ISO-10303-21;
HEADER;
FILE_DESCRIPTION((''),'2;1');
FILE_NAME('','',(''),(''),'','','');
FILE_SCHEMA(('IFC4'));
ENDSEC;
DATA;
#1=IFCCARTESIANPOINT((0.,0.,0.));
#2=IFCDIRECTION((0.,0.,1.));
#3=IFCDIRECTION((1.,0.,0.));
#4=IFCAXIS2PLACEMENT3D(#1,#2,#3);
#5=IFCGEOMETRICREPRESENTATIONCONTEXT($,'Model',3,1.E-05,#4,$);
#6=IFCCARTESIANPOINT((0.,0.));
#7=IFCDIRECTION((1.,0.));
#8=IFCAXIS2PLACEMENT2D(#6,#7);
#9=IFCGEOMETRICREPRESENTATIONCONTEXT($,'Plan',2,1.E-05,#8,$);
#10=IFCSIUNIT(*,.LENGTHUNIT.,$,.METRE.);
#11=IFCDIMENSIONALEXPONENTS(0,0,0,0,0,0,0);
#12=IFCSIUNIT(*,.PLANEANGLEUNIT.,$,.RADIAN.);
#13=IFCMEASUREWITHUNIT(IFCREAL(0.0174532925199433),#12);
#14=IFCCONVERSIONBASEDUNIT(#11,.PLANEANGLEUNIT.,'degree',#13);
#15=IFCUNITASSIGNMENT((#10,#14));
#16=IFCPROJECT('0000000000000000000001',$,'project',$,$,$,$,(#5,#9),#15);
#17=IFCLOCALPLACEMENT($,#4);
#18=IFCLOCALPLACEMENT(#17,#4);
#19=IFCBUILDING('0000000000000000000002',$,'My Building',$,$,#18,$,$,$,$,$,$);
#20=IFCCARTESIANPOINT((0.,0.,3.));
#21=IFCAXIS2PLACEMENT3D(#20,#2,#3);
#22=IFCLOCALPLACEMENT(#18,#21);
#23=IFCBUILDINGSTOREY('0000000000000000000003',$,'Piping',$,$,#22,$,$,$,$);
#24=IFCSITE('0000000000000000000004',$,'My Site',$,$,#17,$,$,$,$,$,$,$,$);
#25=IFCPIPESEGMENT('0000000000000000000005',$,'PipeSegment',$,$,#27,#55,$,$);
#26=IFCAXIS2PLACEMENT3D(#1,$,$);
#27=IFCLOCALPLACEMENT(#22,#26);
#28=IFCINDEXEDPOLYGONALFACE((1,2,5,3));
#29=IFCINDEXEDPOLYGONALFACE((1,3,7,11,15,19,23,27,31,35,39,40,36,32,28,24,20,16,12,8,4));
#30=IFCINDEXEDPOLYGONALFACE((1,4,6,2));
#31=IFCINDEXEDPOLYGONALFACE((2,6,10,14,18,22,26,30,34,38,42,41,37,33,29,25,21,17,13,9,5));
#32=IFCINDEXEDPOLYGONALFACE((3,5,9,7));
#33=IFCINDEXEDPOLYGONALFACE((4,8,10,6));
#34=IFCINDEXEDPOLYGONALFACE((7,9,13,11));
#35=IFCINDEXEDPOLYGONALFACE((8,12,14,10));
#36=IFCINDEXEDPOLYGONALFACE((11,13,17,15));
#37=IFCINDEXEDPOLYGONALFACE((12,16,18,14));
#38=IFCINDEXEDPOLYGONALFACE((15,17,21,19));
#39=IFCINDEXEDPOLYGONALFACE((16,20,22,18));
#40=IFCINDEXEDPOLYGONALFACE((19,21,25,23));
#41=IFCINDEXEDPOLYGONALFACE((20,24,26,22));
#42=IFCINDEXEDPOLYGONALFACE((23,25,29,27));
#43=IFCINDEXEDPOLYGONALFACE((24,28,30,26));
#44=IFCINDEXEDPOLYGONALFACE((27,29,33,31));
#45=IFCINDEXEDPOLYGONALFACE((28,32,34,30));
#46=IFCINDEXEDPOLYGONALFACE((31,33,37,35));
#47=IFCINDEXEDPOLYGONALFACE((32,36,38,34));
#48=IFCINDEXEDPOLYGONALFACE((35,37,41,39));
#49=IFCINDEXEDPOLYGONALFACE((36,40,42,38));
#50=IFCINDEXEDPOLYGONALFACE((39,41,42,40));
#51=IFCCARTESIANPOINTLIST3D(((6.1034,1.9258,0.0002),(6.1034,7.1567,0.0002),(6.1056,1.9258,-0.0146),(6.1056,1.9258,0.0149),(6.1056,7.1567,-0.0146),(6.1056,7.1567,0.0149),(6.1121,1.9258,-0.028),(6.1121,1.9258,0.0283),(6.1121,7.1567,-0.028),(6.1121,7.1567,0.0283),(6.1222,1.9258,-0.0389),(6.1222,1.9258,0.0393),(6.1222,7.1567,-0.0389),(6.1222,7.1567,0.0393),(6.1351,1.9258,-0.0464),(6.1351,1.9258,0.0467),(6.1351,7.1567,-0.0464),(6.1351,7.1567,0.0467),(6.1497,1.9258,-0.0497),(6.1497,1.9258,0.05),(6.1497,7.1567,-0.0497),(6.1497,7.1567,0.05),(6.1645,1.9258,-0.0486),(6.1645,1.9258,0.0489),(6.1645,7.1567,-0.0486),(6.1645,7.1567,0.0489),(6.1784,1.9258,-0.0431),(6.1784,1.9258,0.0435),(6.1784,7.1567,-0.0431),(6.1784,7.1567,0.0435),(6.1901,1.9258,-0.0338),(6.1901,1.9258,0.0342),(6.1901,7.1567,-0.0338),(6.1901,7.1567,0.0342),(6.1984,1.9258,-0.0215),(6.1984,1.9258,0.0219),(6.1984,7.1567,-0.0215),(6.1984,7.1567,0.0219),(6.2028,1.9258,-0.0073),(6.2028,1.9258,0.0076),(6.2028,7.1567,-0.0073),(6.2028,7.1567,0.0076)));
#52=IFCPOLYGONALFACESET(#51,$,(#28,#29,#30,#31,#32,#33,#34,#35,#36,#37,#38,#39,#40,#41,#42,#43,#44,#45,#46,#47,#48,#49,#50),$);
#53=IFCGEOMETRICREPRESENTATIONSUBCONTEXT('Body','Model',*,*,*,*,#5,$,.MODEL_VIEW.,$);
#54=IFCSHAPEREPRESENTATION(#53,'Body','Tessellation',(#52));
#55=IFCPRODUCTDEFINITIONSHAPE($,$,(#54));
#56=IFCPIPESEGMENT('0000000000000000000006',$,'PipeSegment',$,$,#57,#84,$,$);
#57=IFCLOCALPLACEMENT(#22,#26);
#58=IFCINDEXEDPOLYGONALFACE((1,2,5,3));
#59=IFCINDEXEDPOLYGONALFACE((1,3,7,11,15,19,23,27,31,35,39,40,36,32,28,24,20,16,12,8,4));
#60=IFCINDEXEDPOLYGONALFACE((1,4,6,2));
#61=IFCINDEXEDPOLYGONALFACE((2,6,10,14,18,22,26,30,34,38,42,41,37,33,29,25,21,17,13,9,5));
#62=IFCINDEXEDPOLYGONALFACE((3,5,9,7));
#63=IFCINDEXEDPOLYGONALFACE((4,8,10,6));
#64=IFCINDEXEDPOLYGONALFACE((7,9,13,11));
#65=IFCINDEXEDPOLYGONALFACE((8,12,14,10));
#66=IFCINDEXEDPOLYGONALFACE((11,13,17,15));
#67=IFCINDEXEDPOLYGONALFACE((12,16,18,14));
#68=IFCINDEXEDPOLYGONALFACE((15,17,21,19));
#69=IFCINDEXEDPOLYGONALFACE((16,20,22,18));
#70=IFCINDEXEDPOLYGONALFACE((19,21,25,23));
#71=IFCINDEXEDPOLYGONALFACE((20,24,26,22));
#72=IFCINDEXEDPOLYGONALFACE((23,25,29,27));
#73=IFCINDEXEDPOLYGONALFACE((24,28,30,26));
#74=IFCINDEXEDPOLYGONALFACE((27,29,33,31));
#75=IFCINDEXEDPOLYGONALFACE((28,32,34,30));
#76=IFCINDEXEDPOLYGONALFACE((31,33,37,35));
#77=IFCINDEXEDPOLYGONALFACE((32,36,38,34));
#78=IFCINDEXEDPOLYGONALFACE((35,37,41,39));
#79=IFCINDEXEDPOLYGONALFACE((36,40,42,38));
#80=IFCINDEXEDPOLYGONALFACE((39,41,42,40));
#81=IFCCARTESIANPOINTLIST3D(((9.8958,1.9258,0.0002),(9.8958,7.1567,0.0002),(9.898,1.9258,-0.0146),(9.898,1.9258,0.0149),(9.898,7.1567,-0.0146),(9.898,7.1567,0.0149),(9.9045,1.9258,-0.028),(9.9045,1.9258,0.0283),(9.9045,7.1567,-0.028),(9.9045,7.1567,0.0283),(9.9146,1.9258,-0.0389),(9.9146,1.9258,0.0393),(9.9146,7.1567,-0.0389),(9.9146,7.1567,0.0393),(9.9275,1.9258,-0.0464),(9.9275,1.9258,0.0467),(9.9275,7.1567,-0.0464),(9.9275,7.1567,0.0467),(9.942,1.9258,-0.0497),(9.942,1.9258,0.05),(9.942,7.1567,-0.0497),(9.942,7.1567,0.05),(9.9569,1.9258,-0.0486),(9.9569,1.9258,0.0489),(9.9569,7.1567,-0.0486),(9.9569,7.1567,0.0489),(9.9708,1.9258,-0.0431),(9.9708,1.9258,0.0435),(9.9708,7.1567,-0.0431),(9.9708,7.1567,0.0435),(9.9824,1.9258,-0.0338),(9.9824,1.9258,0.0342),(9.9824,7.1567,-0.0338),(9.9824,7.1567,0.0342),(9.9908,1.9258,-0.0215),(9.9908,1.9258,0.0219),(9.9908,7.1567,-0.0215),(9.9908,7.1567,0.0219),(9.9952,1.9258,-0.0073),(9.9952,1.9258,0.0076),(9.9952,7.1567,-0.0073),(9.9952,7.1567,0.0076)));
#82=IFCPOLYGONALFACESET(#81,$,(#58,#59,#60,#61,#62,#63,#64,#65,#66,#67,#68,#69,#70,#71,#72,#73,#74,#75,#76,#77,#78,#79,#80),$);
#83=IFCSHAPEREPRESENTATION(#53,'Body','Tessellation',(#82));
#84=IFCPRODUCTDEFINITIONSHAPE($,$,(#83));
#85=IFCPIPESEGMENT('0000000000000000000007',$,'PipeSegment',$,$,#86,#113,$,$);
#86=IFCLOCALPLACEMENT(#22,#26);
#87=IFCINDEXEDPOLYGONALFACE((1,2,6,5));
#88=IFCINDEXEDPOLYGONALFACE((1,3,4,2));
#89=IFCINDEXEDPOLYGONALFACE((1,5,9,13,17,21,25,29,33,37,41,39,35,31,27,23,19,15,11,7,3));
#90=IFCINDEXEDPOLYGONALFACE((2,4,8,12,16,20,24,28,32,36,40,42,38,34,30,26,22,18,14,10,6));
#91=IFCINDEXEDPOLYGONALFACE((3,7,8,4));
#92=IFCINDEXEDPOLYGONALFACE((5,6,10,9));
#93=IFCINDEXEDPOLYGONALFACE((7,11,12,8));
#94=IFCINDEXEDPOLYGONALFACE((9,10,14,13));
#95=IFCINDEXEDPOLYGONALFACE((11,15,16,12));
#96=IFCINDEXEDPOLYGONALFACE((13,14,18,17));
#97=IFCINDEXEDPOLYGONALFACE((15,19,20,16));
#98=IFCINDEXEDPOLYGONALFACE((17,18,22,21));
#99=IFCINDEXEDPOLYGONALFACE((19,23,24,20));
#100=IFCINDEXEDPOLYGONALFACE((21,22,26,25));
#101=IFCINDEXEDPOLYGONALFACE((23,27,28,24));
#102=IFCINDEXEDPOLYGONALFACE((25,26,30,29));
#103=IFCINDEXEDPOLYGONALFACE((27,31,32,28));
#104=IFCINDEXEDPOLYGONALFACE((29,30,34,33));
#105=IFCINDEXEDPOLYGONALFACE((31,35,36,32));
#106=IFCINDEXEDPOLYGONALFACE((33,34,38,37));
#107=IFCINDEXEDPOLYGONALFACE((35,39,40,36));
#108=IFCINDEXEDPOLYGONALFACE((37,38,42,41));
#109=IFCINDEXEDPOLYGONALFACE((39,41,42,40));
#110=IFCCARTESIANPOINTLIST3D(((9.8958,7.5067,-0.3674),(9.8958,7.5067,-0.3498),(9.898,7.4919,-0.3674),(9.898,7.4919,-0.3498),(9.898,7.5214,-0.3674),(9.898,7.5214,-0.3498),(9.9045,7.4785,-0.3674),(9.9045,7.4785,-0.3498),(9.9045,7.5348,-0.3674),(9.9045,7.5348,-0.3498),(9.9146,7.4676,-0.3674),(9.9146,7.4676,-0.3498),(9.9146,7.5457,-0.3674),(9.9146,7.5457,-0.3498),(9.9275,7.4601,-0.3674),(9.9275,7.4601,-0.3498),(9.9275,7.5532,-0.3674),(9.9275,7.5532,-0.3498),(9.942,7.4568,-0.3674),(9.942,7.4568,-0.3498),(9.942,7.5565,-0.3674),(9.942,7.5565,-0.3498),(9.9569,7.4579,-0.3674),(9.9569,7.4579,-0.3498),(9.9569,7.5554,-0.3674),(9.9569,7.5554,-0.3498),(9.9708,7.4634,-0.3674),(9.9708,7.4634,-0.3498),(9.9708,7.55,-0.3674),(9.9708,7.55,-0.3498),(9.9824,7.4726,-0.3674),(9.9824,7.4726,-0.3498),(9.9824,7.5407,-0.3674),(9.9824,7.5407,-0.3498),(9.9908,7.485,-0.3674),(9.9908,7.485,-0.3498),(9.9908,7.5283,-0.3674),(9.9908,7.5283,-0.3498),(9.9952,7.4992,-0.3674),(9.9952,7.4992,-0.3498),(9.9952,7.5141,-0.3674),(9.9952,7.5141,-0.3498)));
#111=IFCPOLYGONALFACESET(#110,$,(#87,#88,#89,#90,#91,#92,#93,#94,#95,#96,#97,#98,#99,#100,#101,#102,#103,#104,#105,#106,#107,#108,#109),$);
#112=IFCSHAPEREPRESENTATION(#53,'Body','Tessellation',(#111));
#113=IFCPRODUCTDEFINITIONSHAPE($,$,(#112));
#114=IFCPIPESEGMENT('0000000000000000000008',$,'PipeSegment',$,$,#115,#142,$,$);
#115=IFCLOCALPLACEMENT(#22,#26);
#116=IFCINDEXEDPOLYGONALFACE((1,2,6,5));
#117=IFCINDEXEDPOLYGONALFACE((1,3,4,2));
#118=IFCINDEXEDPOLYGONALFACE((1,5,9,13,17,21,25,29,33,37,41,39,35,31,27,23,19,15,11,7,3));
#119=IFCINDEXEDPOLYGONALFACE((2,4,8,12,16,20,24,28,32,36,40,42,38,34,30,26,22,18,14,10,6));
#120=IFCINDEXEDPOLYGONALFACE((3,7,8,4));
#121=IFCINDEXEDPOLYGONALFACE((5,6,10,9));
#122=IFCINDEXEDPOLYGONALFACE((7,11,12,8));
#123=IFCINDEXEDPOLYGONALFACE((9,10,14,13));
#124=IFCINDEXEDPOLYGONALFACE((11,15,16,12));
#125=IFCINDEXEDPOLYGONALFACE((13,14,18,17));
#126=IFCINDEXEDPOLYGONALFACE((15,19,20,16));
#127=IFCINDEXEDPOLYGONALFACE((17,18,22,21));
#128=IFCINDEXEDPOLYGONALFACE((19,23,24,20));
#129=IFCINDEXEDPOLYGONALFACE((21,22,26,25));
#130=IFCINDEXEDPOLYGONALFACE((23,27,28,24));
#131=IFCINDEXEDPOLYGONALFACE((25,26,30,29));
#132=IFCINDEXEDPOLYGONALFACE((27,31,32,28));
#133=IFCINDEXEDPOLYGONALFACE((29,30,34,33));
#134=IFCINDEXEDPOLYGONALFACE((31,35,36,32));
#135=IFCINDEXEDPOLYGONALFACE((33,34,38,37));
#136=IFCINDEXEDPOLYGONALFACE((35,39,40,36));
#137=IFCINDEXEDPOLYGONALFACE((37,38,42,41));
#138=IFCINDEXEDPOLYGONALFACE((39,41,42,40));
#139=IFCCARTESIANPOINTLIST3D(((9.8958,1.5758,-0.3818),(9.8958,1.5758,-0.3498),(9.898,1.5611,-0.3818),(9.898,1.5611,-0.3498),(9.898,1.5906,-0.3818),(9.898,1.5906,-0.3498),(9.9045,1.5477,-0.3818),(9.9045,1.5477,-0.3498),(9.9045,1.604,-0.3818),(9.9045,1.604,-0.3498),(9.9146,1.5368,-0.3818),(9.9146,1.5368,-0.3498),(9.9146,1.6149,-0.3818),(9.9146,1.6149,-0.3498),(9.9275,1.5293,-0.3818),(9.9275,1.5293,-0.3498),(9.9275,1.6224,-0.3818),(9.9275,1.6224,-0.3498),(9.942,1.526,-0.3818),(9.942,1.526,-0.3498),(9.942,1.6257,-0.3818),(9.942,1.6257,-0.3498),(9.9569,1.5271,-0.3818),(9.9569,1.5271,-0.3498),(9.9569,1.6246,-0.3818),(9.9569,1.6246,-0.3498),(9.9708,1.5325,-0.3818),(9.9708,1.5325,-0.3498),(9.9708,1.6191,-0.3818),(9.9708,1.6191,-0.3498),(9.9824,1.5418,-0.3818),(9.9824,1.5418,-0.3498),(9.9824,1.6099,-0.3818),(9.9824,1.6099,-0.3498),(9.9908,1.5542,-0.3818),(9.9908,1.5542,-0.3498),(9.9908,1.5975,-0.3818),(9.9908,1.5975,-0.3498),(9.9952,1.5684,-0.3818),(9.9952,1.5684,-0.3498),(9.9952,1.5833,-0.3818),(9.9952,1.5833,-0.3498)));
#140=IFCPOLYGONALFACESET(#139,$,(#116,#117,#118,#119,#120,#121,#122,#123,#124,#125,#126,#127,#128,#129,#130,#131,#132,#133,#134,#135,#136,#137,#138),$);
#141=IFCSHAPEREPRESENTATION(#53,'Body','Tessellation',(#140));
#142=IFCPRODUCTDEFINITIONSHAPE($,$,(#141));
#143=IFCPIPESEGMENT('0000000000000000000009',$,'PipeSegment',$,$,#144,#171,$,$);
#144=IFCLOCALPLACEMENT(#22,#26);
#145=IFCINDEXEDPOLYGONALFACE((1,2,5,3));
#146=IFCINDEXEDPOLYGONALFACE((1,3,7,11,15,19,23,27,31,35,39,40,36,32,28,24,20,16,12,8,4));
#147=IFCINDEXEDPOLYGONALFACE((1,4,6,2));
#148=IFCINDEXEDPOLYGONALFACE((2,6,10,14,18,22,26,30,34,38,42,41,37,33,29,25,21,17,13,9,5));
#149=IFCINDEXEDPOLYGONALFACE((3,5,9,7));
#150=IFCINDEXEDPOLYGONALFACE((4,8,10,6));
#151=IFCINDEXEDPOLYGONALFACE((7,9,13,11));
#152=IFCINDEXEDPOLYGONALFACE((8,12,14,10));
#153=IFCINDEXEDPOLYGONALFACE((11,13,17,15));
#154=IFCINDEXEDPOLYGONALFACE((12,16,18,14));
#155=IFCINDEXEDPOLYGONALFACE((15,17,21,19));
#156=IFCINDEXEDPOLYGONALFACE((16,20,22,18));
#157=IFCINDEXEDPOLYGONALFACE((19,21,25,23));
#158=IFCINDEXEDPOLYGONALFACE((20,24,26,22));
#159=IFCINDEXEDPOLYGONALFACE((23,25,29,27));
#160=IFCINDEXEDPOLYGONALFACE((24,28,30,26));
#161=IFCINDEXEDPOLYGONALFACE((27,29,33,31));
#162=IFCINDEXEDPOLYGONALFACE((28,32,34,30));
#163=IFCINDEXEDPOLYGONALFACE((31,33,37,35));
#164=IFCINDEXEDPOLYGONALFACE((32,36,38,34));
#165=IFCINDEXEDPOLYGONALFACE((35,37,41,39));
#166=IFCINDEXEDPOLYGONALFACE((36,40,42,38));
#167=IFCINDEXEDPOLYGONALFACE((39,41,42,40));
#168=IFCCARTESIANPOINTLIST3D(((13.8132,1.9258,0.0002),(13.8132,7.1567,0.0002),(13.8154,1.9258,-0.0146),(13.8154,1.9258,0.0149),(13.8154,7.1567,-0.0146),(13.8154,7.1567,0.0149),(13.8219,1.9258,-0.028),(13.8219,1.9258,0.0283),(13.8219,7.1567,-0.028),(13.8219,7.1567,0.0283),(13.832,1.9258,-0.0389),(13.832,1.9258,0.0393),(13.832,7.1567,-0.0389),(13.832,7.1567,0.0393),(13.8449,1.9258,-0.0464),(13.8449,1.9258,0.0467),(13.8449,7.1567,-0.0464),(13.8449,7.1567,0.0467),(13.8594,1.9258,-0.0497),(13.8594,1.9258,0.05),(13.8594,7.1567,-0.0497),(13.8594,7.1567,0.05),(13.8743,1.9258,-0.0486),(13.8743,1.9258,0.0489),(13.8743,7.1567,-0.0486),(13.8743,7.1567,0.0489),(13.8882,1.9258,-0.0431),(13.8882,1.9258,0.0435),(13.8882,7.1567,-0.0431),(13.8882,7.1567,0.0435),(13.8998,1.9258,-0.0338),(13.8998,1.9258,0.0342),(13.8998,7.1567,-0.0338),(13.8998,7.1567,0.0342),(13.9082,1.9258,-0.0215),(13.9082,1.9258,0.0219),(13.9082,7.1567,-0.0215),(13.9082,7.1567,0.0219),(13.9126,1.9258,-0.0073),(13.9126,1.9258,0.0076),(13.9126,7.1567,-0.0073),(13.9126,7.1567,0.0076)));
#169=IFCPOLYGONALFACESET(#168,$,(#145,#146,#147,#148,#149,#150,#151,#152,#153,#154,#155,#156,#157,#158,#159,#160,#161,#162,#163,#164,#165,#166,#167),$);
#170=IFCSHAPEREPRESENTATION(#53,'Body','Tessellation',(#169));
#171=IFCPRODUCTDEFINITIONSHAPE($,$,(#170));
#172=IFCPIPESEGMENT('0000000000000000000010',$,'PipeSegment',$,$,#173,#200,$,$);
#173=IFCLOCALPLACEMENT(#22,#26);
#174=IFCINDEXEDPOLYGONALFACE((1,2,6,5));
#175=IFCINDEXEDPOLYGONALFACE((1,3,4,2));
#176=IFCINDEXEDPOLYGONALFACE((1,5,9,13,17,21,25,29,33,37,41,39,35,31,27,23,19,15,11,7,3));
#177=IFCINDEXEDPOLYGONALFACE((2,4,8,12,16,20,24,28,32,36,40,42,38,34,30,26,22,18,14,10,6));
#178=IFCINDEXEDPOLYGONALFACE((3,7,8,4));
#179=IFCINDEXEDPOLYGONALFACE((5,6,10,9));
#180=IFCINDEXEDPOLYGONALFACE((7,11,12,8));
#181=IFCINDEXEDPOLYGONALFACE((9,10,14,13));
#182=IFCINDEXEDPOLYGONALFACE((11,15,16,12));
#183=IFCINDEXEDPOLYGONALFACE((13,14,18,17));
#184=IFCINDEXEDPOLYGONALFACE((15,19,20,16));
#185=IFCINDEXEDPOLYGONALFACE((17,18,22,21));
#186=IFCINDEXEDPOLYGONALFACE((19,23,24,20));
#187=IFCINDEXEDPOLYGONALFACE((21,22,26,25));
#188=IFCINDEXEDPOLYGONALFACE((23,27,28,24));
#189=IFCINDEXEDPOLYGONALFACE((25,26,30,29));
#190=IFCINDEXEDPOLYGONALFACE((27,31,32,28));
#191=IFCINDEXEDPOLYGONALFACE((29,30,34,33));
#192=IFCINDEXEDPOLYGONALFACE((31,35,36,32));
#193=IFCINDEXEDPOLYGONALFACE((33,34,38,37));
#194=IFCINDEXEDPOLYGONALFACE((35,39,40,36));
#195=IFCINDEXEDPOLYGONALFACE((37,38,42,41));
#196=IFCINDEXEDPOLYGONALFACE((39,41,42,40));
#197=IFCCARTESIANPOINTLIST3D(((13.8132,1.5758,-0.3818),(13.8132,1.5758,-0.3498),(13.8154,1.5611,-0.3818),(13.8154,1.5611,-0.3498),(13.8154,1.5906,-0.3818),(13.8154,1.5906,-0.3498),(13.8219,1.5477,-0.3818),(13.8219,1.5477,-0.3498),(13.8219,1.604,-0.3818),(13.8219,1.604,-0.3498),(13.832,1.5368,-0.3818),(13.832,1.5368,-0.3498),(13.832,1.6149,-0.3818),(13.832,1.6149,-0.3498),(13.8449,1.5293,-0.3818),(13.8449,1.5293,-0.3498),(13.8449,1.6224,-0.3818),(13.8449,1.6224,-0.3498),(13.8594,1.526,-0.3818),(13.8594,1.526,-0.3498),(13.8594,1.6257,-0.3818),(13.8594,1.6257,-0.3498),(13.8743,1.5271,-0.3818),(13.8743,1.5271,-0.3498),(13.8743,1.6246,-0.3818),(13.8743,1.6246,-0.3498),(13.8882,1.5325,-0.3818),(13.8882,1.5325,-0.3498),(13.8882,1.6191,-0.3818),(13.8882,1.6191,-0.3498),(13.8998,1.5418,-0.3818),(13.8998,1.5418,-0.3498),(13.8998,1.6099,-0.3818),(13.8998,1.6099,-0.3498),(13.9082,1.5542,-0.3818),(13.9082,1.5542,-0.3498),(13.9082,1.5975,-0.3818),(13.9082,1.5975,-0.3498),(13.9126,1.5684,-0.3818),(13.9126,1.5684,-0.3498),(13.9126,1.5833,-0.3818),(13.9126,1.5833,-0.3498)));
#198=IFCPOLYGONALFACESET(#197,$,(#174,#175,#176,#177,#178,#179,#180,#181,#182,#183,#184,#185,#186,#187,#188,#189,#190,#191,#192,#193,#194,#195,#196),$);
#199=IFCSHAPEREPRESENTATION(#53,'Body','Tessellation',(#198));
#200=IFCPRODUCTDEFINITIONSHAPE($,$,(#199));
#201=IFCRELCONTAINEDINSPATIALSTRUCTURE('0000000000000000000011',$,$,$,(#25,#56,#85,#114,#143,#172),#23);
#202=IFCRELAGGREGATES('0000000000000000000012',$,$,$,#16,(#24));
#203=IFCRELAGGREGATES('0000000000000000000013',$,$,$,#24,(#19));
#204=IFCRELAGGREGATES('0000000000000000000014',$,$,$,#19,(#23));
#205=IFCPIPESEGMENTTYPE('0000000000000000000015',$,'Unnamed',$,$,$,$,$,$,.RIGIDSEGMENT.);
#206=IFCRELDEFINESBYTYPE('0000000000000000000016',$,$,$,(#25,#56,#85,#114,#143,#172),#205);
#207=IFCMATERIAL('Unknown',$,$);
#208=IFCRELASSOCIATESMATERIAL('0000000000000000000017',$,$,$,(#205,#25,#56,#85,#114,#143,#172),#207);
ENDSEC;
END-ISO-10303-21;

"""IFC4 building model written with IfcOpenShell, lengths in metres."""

from ifc_helpers import new_model, entity, si_unit, converted_unit, frame, origin_with_axes, origin_2d_with_axis, place, context, subcontext, project, spatial, circle, extrude, material, material_profile, profile_set, profile_usage, type_object, element, save


model = new_model("IFC4")

# Units and contexts
model_context = context("Model", 3, precision=1e-05, world=origin_with_axes())
plan_context = context("Plan", 2, precision=1e-05, world=origin_2d_with_axis())
body_context = subcontext(model_context, "Body", "Model", "MODEL_VIEW")
ifc_project = project(units=[si_unit("LENGTHUNIT", "METRE"), converted_unit("PLANEANGLEUNIT", "degree", entity("IfcReal", 0.0174532925199433), si_unit("PLANEANGLEUNIT", "RADIAN"), dimensions=[0, 0, 0, 0, 0, 0, 0])], contexts=[model_context, plan_context])

# Site, building, storey
site_placement = place(None, origin_with_axes())
site = spatial("IfcSite", under=ifc_project, at=site_placement, Name="My Site")
building_placement = place(site_placement, origin_with_axes())
building = spatial("IfcBuilding", under=site, at=building_placement, Name="My Building")
storey_placement = place(building_placement, frame((0.0, 0.0, 3.0), z_axis=(0.0, 0.0, 1.0), x_axis=(1.0, 0.0, 0.0)))
storey = spatial("IfcBuildingStorey", under=building, at=storey_placement, Name="Piping")

# Pipe segments
ifc_material = material(Name="Unknown")
ifc_material_profile = material_profile(ifc_material, circle(Radius=0.05))
ifc_profile_set = profile_set([ifc_material_profile])
pipe_segment_type = type_object("IfcPipeSegmentType", Name="Unnamed", PredefinedType="RIGIDSEGMENT", material=ifc_profile_set)
ifc_profile_usage_1 = profile_usage(ifc_profile_set, cardinal=5)
pipe_segment_1_placement = place(storey_placement, frame((6.1534, 1.9258, 0.0002), z_axis=(0.0, 1.0, 0.0), x_axis=(-1.0, 0.0, 0.0)))
element("IfcPipeSegment", 1, at=pipe_segment_1_placement, inside=storey, type_object=pipe_segment_type, material=ifc_profile_usage_1, Name="PipeSegment", context=body_context, shape_type="SweptSolid", body=[
    extrude(circle(Radius=0.05), origin_with_axes(), (0.0, 0.0, 1.0), 5.2308),
])
ifc_profile_usage_2 = profile_usage(ifc_profile_set, cardinal=5)
pipe_segment_2_placement = place(storey_placement, frame((9.9458, 1.9258, 0.0002), z_axis=(0.0, 1.0, 0.0), x_axis=(-1.0, 0.0, 0.0)))
element("IfcPipeSegment", 2, at=pipe_segment_2_placement, inside=storey, type_object=pipe_segment_type, material=ifc_profile_usage_2, Name="PipeSegment", context=body_context, shape_type="SweptSolid", body=[
    extrude(circle(Radius=0.05), origin_with_axes(), (0.0, 0.0, 1.0), 5.2308),
])
ifc_profile_usage_3 = profile_usage(ifc_profile_set, cardinal=5)
pipe_segment_3_placement = place(storey_placement, frame((9.9458, 7.5067, -0.3498), z_axis=(0.0, 0.0, -1.0), x_axis=(-1.0, 0.0, 0.0)))
element("IfcPipeSegment", 3, at=pipe_segment_3_placement, inside=storey, type_object=pipe_segment_type, material=ifc_profile_usage_3, Name="PipeSegment", context=body_context, shape_type="SweptSolid", body=[
    extrude(circle(Radius=0.05), origin_with_axes(), (0.0, 0.0, 1.0), 0.0175),
])
ifc_profile_usage_4 = profile_usage(ifc_profile_set, cardinal=5)
pipe_segment_4_placement = place(storey_placement, frame((9.9458, 1.5758, -0.3498), z_axis=(0.0, 0.0, -1.0), x_axis=(-1.0, 0.0, 0.0)))
element("IfcPipeSegment", 4, at=pipe_segment_4_placement, inside=storey, type_object=pipe_segment_type, material=ifc_profile_usage_4, Name="PipeSegment", context=body_context, shape_type="SweptSolid", body=[
    extrude(circle(Radius=0.05), origin_with_axes(), (0.0, 0.0, 1.0), 0.0319),
])
ifc_profile_usage_5 = profile_usage(ifc_profile_set, cardinal=5)
pipe_segment_5_placement = place(storey_placement, frame((13.8632, 1.9258, 0.0002), z_axis=(0.0, 1.0, 0.0), x_axis=(-1.0, 0.0, 0.0)))
element("IfcPipeSegment", 5, at=pipe_segment_5_placement, inside=storey, type_object=pipe_segment_type, material=ifc_profile_usage_5, Name="PipeSegment", context=body_context, shape_type="SweptSolid", body=[
    extrude(circle(Radius=0.05), origin_with_axes(), (0.0, 0.0, 1.0), 5.2308),
])
ifc_profile_usage_6 = profile_usage(ifc_profile_set, cardinal=5)
pipe_segment_6_placement = place(storey_placement, frame((13.8632, 1.5758, -0.3498), z_axis=(0.0, 0.0, -1.0), x_axis=(-1.0, 0.0, 0.0)))
element("IfcPipeSegment", 6, at=pipe_segment_6_placement, inside=storey, type_object=pipe_segment_type, material=ifc_profile_usage_6, Name="PipeSegment", context=body_context, shape_type="SweptSolid", body=[
    extrude(circle(Radius=0.05), origin_with_axes(), (0.0, 0.0, 1.0), 0.0319),
])

save(model, "model.ifc")
